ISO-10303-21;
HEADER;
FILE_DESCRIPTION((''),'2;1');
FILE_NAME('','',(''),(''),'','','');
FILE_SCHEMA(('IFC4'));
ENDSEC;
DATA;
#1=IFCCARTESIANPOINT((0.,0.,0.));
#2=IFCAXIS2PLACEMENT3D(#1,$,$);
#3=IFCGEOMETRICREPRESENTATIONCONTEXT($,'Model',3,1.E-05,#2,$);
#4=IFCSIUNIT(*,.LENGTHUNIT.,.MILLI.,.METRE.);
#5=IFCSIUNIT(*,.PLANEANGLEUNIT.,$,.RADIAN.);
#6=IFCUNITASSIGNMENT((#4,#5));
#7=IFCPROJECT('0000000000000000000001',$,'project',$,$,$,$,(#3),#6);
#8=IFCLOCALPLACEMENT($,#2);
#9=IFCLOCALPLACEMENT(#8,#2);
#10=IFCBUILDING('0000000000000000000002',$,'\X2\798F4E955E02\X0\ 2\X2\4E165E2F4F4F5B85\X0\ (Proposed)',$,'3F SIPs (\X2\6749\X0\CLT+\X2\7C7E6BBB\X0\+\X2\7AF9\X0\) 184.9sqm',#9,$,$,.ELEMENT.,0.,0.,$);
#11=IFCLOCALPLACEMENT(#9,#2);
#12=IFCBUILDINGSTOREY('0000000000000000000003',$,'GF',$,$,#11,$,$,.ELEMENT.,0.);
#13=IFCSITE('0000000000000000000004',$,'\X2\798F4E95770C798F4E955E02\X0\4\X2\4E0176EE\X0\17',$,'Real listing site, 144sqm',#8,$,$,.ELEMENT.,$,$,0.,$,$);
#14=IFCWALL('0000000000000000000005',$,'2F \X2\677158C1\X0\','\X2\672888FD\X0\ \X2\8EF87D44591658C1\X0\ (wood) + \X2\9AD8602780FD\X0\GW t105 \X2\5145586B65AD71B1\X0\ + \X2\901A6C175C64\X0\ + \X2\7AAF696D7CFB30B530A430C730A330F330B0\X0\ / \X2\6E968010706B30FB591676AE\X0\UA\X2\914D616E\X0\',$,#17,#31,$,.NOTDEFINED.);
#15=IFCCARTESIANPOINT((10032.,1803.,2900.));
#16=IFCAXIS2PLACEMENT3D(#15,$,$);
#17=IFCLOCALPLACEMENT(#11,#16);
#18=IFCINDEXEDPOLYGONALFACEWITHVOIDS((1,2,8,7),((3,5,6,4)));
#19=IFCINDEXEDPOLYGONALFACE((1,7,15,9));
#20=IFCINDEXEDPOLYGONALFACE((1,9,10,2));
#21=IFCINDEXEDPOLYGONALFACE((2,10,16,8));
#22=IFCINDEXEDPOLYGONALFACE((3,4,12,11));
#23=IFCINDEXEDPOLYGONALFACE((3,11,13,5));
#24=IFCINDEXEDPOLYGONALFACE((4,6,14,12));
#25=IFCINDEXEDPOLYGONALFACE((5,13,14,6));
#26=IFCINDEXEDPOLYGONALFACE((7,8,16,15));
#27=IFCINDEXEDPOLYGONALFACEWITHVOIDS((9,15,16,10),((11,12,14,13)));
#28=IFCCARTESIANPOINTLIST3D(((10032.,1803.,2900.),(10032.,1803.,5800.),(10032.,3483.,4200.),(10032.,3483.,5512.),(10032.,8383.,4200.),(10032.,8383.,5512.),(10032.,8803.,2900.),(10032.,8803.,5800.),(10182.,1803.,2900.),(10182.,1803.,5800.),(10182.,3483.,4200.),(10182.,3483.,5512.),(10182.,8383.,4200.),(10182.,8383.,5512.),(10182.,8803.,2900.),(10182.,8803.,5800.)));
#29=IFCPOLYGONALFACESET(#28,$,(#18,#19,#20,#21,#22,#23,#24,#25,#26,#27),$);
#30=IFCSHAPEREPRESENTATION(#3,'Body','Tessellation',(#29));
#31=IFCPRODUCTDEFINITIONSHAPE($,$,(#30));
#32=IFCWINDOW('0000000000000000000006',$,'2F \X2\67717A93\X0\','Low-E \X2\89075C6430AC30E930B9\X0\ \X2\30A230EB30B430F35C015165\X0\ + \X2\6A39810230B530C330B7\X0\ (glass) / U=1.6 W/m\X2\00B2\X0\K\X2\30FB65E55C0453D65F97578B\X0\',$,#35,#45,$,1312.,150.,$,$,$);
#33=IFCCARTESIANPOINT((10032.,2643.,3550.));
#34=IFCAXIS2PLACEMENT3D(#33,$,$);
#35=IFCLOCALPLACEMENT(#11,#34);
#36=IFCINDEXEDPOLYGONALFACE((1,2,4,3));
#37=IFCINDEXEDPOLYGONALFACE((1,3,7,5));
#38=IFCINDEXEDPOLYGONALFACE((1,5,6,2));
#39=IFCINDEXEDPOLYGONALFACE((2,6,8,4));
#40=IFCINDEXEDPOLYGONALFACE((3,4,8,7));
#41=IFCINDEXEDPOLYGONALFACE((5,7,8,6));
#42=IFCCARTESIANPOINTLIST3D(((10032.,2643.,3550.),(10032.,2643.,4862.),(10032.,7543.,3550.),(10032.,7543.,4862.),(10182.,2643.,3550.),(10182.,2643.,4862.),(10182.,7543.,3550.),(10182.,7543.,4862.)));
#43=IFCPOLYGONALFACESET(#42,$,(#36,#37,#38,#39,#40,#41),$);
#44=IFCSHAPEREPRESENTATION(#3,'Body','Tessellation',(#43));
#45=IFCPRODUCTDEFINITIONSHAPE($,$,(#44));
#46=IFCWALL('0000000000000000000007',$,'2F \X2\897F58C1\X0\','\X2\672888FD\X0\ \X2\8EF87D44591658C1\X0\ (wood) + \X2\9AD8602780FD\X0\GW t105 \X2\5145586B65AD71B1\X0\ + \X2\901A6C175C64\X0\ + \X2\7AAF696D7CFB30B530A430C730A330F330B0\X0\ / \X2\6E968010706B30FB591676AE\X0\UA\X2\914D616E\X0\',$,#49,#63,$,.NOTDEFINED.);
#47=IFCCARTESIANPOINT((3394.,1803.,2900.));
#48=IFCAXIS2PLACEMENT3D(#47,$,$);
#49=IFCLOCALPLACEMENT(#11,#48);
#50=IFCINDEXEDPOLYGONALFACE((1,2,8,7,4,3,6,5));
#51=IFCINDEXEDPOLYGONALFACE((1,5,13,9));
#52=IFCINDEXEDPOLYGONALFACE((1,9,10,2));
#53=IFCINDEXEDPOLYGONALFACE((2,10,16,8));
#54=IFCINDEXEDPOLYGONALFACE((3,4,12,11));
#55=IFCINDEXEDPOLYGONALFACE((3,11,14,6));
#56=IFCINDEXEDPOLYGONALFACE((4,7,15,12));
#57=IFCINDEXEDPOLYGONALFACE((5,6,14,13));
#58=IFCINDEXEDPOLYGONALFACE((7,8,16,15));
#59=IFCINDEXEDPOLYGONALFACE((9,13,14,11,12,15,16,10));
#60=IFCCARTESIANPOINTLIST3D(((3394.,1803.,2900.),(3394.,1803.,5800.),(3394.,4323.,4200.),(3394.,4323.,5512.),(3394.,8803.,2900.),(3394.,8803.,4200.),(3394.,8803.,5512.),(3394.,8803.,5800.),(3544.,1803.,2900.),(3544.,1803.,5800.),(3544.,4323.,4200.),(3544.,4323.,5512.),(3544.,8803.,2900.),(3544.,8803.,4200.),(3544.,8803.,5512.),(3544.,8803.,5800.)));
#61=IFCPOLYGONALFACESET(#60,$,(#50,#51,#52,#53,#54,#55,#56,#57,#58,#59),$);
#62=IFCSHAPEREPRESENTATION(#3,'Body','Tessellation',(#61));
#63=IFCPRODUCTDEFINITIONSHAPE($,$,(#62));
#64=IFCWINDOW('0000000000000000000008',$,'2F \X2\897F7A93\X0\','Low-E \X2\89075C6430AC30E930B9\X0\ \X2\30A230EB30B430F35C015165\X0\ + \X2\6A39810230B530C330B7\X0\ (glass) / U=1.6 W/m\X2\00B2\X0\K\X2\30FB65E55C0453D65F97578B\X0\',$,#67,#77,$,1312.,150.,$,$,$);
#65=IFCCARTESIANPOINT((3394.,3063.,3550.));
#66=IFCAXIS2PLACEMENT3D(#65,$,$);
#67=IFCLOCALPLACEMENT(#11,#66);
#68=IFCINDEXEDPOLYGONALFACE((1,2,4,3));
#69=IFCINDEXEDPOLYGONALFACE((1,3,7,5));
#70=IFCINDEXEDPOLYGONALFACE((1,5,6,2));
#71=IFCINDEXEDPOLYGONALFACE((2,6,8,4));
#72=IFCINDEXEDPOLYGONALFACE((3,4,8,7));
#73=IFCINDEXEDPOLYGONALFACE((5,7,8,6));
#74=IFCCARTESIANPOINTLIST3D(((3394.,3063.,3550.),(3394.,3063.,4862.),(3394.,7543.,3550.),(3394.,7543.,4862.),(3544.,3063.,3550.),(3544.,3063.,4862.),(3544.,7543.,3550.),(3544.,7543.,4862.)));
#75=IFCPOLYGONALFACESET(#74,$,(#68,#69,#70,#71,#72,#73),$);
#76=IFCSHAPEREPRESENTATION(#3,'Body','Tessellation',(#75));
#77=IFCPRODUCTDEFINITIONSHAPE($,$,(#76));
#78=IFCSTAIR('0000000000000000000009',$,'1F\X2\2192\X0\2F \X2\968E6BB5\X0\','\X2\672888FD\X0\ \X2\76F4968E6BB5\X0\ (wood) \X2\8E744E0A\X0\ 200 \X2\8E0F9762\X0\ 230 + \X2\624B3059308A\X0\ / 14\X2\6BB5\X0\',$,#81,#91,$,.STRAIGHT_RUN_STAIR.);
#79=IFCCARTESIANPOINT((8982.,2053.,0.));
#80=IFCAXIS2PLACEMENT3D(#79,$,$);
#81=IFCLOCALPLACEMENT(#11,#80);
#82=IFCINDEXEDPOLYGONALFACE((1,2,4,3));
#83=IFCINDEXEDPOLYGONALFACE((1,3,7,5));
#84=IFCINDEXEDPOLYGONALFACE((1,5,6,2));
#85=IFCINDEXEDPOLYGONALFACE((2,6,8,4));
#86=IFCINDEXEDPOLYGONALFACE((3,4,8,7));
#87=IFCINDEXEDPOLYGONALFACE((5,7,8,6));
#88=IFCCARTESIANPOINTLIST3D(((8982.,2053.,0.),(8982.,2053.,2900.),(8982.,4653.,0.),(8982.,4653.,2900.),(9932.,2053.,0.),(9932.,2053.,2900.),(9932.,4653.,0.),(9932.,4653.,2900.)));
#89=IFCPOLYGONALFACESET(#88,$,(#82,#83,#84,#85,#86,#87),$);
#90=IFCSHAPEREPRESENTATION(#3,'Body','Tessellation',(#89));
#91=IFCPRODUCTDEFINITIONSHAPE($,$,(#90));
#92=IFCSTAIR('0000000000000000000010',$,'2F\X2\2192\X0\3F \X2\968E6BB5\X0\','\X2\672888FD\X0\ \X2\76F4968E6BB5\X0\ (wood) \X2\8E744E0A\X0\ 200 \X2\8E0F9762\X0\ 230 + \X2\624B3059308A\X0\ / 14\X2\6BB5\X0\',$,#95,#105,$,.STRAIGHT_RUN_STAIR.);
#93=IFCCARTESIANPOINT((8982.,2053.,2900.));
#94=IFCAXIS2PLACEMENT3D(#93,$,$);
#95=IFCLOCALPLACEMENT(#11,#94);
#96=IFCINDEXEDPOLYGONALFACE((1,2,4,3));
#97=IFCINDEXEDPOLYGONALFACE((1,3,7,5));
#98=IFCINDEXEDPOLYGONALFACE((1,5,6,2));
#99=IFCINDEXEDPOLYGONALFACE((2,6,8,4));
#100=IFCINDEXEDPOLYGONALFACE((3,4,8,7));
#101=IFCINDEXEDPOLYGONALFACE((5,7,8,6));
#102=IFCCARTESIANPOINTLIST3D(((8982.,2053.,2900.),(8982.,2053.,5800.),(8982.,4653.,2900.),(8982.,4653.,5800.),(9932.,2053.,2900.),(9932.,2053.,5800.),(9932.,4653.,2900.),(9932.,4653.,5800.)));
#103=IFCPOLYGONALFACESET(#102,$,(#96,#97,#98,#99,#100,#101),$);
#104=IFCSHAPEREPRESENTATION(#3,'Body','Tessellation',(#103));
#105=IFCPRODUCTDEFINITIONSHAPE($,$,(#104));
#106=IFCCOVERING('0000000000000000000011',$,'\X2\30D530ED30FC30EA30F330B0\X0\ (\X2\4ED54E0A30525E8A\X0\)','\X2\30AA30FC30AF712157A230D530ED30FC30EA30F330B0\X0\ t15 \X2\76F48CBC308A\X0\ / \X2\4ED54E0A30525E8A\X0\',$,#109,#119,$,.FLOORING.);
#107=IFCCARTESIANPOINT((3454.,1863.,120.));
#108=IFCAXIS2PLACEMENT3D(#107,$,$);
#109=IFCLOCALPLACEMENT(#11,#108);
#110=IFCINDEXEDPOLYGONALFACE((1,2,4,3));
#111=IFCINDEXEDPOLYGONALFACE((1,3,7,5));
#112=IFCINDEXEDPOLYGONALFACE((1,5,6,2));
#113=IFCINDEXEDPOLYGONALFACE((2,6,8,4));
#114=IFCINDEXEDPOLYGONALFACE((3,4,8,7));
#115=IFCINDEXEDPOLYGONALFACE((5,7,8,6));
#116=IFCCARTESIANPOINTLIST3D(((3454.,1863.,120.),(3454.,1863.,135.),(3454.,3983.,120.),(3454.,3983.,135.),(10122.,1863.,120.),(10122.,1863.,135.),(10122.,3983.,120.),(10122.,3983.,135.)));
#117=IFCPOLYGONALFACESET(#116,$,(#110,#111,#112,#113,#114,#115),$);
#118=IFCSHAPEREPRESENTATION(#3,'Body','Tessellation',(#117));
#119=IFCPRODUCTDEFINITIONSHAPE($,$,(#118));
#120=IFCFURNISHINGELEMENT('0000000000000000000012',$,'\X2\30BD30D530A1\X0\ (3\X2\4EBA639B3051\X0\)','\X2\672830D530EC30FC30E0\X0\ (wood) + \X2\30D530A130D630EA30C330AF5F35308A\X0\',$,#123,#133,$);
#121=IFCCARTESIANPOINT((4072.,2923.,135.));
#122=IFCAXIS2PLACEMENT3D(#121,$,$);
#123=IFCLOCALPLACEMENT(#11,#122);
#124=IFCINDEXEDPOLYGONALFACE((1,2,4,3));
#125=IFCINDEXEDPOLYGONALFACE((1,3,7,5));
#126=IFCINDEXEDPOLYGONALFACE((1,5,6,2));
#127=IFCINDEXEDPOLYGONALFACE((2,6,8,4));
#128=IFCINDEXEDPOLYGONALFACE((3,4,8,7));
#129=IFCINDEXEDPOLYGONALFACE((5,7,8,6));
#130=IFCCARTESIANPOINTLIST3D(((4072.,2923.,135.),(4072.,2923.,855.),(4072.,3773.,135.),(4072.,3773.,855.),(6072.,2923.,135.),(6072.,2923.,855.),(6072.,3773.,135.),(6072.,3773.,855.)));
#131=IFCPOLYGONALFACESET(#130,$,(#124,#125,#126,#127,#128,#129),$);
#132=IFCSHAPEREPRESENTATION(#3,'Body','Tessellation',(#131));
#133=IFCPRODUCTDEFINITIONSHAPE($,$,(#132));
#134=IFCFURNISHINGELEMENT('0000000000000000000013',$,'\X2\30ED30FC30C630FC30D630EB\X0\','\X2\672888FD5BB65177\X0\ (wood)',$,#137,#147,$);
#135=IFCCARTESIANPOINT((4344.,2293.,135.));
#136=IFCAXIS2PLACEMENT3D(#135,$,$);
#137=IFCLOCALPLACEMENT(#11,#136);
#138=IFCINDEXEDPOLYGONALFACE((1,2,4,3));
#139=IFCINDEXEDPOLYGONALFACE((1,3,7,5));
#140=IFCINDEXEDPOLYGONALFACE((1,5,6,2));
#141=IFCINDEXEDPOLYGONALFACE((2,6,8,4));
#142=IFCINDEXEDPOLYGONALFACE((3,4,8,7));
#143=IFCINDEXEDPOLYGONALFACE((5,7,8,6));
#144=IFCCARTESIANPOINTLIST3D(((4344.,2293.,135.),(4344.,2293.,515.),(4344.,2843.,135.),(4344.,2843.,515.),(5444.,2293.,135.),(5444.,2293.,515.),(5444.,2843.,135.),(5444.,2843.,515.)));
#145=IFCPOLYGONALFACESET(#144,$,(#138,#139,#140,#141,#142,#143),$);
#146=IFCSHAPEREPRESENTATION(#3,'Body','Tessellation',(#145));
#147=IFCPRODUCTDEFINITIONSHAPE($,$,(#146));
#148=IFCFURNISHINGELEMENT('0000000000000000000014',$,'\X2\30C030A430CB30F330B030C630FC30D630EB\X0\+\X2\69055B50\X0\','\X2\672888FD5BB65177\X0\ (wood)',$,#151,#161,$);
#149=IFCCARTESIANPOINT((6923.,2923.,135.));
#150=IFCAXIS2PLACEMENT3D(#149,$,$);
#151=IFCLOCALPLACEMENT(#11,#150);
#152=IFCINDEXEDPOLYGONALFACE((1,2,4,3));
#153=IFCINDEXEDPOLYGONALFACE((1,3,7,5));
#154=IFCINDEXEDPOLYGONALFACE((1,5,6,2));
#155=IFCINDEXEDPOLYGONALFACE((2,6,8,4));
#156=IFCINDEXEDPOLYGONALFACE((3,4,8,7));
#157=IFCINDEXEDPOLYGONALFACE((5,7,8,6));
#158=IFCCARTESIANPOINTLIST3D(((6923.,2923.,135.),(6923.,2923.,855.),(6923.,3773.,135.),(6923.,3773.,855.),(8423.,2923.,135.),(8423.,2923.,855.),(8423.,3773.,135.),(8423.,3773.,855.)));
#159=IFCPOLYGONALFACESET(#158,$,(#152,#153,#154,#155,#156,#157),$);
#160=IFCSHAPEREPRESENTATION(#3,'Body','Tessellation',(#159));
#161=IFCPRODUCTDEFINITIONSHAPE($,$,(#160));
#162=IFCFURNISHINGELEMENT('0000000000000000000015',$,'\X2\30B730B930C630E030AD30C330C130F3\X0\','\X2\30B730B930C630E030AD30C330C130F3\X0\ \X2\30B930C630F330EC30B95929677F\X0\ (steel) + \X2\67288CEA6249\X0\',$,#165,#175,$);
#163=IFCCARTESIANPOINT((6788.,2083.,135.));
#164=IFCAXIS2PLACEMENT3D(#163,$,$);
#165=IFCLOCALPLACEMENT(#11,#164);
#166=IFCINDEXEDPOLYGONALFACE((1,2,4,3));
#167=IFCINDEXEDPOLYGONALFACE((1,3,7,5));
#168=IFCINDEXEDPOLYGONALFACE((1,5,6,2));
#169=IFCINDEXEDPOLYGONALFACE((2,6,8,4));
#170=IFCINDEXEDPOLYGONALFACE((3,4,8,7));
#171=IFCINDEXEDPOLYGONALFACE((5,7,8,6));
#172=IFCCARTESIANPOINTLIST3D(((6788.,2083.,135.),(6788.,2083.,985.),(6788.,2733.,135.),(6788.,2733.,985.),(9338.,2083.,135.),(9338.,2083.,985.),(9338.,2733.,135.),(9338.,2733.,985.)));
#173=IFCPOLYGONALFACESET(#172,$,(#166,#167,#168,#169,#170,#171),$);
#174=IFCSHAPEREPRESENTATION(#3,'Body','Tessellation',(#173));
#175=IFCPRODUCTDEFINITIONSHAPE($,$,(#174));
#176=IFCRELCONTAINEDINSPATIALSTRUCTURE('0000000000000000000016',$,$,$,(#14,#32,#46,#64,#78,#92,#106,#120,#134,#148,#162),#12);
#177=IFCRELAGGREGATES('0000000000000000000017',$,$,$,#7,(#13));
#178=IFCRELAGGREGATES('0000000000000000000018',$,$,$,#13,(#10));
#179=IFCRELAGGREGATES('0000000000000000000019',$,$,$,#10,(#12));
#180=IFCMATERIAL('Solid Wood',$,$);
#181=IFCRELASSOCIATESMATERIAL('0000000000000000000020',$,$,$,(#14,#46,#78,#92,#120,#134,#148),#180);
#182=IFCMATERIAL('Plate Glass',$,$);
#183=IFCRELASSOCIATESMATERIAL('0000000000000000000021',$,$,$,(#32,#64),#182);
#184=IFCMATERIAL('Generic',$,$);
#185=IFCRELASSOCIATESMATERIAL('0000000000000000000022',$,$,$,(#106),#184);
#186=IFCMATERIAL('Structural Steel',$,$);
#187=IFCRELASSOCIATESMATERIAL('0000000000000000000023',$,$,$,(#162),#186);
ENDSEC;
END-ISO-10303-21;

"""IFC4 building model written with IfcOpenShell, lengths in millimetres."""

from ifc_helpers import new_model, si_unit, frame, frame_2d, origin, place, context, project, spatial, rectangle, extrude, material, element, fill, save


model = new_model("IFC4")

# Units and contexts
model_context = context("Model", 3, precision=1e-05, world=origin())
ifc_project = project(units=[si_unit("LENGTHUNIT", "METRE", prefix="MILLI"), si_unit("PLANEANGLEUNIT", "RADIAN")], contexts=[model_context])

# Site, building, storey
site_placement = place(None, origin())
site = spatial("IfcSite", under=ifc_project, at=site_placement, Name="福井県福井市4丁目17", ObjectType="Real listing site, 144sqm", CompositionType="ELEMENT", RefElevation=0.0)
building_placement = place(site_placement, origin())
building = spatial("IfcBuilding", under=site, at=building_placement, Name="福井市 2世帯住宅 (Proposed)", ObjectType="3F SIPs (杉CLT+籾殻+竹) 184.9sqm", CompositionType="ELEMENT", ElevationOfRefHeight=0.0, ElevationOfTerrain=0.0)
storey_placement = place(building_placement, origin())
storey = spatial("IfcBuildingStorey", under=building, at=storey_placement, Name="GF", CompositionType="ELEMENT", Elevation=0.0)

# Shared definitions
ifc_material_1 = material(Name="Solid Wood")
ifc_material_2 = material(Name="Generic")

# Shared definitions
ifc_material_3 = material(Name="Plate Glass")

# Walls, openings, windows
wall_1_placement = place(storey_placement, frame((10032.0, 1803.0, 2900.0)))
wall_1 = element("IfcWall", 1, at=wall_1_placement, inside=storey, material=ifc_material_1, Name="2F 東壁", Description="木製 軸組外壁 (wood) + 高性能GW t105 充填断熱 + 通気層 + 窯業系サイディング / 準耐火・外皮UA配慮", PredefinedType="NOTDEFINED", context=model_context, shape_type="SweptSolid", body=[
    extrude(rectangle(XDim=150.0, YDim=7000.0, at=frame_2d((75.0, 3500.0))), frame((10032.0, 1803.0, 2900.0)), (0.0, 0.0, 1.0), 2900.0),
])
opening_1_placement = place(storey_placement, frame((10032.0, 2643.0, 3550.0)))
opening_1 = element("IfcOpeningElement", 2, at=opening_1_placement, cuts=wall_1, PredefinedType="NOTDEFINED", context=model_context, shape_type="SweptSolid", body=[
    extrude(rectangle(XDim=150.0, YDim=4900.0, at=frame_2d((75.0, 2450.0))), frame((10032.0, 2643.0, 3550.0)), (0.0, 0.0, 1.0), 1312.0),
])
window_1_placement = place(storey_placement, frame((10032.0, 2643.0, 3550.0)))
window_1 = element("IfcWindow", 3, at=window_1_placement, inside=storey, material=ifc_material_3, Name="2F 東窓", Description="Low-E 複層ガラス アルゴン封入 + 樹脂サッシ (glass) / U=1.6 W/m²K・日射取得型", OverallHeight=1312.0, OverallWidth=150.0, context=model_context, shape_type="SweptSolid", body=[
    extrude(rectangle(XDim=150.0, YDim=4900.0, at=frame_2d((75.0, 2450.0))), frame((10032.0, 2643.0, 3550.0)), (0.0, 0.0, 1.0), 1312.0),
])
fill(opening_1, window_1)
wall_2_placement = place(storey_placement, frame((3394.0, 1803.0, 2900.0)))
wall_2 = element("IfcWall", 4, at=wall_2_placement, inside=storey, material=ifc_material_1, Name="2F 西壁", Description="木製 軸組外壁 (wood) + 高性能GW t105 充填断熱 + 通気層 + 窯業系サイディング / 準耐火・外皮UA配慮", PredefinedType="NOTDEFINED", context=model_context, shape_type="SweptSolid", body=[
    extrude(rectangle(XDim=150.0, YDim=7000.0, at=frame_2d((75.0, 3500.0))), frame((3394.0, 1803.0, 2900.0)), (0.0, 0.0, 1.0), 2900.0),
])
opening_2_placement = place(storey_placement, frame((3394.0, 3063.0, 3550.0)))
opening_2 = element("IfcOpeningElement", 5, at=opening_2_placement, cuts=wall_2, PredefinedType="NOTDEFINED", context=model_context, shape_type="SweptSolid", body=[
    extrude(rectangle(XDim=150.0, YDim=4480.0, at=frame_2d((75.0, 2240.0))), frame((3394.0, 3063.0, 3550.0)), (0.0, 0.0, 1.0), 1312.0),
])
window_2_placement = place(storey_placement, frame((3394.0, 3063.0, 3550.0)))
window_2 = element("IfcWindow", 6, at=window_2_placement, inside=storey, material=ifc_material_3, Name="2F 西窓", Description="Low-E 複層ガラス アルゴン封入 + 樹脂サッシ (glass) / U=1.6 W/m²K・日射取得型", OverallHeight=1312.0, OverallWidth=150.0, context=model_context, shape_type="SweptSolid", body=[
    extrude(rectangle(XDim=150.0, YDim=4480.0, at=frame_2d((75.0, 2240.0))), frame((3394.0, 3063.0, 3550.0)), (0.0, 0.0, 1.0), 1312.0),
])
fill(opening_2, window_2)

# Stairs
stair_1_placement = place(storey_placement, frame((8982.0, 2053.0, 0.0)))
element("IfcStair", 7, at=stair_1_placement, inside=storey, material=ifc_material_1, Name="1F→2F 階段", Description="木製 直階段 (wood) 蹴上 200 踏面 230 + 手すり / 14段", PredefinedType="STRAIGHT_RUN_STAIR", context=model_context, shape_type="SweptSolid", body=[
    extrude(rectangle(XDim=950.0, YDim=2600.0, at=frame_2d((475.0, 1300.0))), frame((8982.0, 2053.0, 0.0)), (0.0, 0.0, 1.0), 2900.0),
])
stair_2_placement = place(storey_placement, frame((8982.0, 2053.0, 2900.0)))
element("IfcStair", 8, at=stair_2_placement, inside=storey, material=ifc_material_1, Name="2F→3F 階段", Description="木製 直階段 (wood) 蹴上 200 踏面 230 + 手すり / 14段", PredefinedType="STRAIGHT_RUN_STAIR", context=model_context, shape_type="SweptSolid", body=[
    extrude(rectangle(XDim=950.0, YDim=2600.0, at=frame_2d((475.0, 1300.0))), frame((8982.0, 2053.0, 2900.0)), (0.0, 0.0, 1.0), 2900.0),
])

# Covering
covering_placement = place(storey_placement, frame((3454.0, 1863.0, 120.0)))
element("IfcCovering", 9, at=covering_placement, inside=storey, material=ifc_material_2, Name="フローリング (仕上げ床)", Description="オーク無垢フローリング t15 直貼り / 仕上げ床", PredefinedType="FLOORING", context=model_context, shape_type="SweptSolid", body=[
    extrude(rectangle(XDim=6668.0, YDim=2120.0, at=frame_2d((3334.0, 1060.0))), frame((3454.0, 1863.0, 120.0)), (0.0, 0.0, 1.0), 15.0),
])

# Furnishing elements
furnishing_1_placement = place(storey_placement, frame((4072.0, 2923.0, 135.0)))
element("IfcFurnishingElement", 10, at=furnishing_1_placement, inside=storey, material=ifc_material_1, Name="ソファ (3人掛け)", Description="木フレーム (wood) + ファブリック張り", context=model_context, shape_type="SweptSolid", body=[
    extrude(rectangle(XDim=2000.0, YDim=850.0, at=frame_2d((1000.0, 425.0))), frame((4072.0, 2923.0, 135.0)), (0.0, 0.0, 1.0), 720.0),
])
furnishing_2_placement = place(storey_placement, frame((4344.0, 2293.0, 135.0)))
element("IfcFurnishingElement", 11, at=furnishing_2_placement, inside=storey, material=ifc_material_1, Name="ローテーブル", Description="木製家具 (wood)", context=model_context, shape_type="SweptSolid", body=[
    extrude(rectangle(XDim=1100.0, YDim=550.0, at=frame_2d((550.0, 275.0))), frame((4344.0, 2293.0, 135.0)), (0.0, 0.0, 1.0), 380.0),
])
furnishing_3_placement = place(storey_placement, frame((6923.0, 2923.0, 135.0)))
element("IfcFurnishingElement", 12, at=furnishing_3_placement, inside=storey, material=ifc_material_1, Name="ダイニングテーブル+椅子", Description="木製家具 (wood)", context=model_context, shape_type="SweptSolid", body=[
    extrude(rectangle(XDim=1500.0, YDim=850.0, at=frame_2d((750.0, 425.0))), frame((6923.0, 2923.0, 135.0)), (0.0, 0.0, 1.0), 720.0),
])
ifc_material_4 = material(Name="Structural Steel")
furnishing_4_placement = place(storey_placement, frame((6788.0, 2083.0, 135.0)))
element("IfcFurnishingElement", 13, at=furnishing_4_placement, inside=storey, material=ifc_material_4, Name="システムキッチン", Description="システムキッチン ステンレス天板 (steel) + 木質扉", context=model_context, shape_type="SweptSolid", body=[
    extrude(rectangle(XDim=2550.0, YDim=650.0, at=frame_2d((1275.0, 325.0))), frame((6788.0, 2083.0, 135.0)), (0.0, 0.0, 1.0), 850.0),
])

save(model, "model.ifc")
